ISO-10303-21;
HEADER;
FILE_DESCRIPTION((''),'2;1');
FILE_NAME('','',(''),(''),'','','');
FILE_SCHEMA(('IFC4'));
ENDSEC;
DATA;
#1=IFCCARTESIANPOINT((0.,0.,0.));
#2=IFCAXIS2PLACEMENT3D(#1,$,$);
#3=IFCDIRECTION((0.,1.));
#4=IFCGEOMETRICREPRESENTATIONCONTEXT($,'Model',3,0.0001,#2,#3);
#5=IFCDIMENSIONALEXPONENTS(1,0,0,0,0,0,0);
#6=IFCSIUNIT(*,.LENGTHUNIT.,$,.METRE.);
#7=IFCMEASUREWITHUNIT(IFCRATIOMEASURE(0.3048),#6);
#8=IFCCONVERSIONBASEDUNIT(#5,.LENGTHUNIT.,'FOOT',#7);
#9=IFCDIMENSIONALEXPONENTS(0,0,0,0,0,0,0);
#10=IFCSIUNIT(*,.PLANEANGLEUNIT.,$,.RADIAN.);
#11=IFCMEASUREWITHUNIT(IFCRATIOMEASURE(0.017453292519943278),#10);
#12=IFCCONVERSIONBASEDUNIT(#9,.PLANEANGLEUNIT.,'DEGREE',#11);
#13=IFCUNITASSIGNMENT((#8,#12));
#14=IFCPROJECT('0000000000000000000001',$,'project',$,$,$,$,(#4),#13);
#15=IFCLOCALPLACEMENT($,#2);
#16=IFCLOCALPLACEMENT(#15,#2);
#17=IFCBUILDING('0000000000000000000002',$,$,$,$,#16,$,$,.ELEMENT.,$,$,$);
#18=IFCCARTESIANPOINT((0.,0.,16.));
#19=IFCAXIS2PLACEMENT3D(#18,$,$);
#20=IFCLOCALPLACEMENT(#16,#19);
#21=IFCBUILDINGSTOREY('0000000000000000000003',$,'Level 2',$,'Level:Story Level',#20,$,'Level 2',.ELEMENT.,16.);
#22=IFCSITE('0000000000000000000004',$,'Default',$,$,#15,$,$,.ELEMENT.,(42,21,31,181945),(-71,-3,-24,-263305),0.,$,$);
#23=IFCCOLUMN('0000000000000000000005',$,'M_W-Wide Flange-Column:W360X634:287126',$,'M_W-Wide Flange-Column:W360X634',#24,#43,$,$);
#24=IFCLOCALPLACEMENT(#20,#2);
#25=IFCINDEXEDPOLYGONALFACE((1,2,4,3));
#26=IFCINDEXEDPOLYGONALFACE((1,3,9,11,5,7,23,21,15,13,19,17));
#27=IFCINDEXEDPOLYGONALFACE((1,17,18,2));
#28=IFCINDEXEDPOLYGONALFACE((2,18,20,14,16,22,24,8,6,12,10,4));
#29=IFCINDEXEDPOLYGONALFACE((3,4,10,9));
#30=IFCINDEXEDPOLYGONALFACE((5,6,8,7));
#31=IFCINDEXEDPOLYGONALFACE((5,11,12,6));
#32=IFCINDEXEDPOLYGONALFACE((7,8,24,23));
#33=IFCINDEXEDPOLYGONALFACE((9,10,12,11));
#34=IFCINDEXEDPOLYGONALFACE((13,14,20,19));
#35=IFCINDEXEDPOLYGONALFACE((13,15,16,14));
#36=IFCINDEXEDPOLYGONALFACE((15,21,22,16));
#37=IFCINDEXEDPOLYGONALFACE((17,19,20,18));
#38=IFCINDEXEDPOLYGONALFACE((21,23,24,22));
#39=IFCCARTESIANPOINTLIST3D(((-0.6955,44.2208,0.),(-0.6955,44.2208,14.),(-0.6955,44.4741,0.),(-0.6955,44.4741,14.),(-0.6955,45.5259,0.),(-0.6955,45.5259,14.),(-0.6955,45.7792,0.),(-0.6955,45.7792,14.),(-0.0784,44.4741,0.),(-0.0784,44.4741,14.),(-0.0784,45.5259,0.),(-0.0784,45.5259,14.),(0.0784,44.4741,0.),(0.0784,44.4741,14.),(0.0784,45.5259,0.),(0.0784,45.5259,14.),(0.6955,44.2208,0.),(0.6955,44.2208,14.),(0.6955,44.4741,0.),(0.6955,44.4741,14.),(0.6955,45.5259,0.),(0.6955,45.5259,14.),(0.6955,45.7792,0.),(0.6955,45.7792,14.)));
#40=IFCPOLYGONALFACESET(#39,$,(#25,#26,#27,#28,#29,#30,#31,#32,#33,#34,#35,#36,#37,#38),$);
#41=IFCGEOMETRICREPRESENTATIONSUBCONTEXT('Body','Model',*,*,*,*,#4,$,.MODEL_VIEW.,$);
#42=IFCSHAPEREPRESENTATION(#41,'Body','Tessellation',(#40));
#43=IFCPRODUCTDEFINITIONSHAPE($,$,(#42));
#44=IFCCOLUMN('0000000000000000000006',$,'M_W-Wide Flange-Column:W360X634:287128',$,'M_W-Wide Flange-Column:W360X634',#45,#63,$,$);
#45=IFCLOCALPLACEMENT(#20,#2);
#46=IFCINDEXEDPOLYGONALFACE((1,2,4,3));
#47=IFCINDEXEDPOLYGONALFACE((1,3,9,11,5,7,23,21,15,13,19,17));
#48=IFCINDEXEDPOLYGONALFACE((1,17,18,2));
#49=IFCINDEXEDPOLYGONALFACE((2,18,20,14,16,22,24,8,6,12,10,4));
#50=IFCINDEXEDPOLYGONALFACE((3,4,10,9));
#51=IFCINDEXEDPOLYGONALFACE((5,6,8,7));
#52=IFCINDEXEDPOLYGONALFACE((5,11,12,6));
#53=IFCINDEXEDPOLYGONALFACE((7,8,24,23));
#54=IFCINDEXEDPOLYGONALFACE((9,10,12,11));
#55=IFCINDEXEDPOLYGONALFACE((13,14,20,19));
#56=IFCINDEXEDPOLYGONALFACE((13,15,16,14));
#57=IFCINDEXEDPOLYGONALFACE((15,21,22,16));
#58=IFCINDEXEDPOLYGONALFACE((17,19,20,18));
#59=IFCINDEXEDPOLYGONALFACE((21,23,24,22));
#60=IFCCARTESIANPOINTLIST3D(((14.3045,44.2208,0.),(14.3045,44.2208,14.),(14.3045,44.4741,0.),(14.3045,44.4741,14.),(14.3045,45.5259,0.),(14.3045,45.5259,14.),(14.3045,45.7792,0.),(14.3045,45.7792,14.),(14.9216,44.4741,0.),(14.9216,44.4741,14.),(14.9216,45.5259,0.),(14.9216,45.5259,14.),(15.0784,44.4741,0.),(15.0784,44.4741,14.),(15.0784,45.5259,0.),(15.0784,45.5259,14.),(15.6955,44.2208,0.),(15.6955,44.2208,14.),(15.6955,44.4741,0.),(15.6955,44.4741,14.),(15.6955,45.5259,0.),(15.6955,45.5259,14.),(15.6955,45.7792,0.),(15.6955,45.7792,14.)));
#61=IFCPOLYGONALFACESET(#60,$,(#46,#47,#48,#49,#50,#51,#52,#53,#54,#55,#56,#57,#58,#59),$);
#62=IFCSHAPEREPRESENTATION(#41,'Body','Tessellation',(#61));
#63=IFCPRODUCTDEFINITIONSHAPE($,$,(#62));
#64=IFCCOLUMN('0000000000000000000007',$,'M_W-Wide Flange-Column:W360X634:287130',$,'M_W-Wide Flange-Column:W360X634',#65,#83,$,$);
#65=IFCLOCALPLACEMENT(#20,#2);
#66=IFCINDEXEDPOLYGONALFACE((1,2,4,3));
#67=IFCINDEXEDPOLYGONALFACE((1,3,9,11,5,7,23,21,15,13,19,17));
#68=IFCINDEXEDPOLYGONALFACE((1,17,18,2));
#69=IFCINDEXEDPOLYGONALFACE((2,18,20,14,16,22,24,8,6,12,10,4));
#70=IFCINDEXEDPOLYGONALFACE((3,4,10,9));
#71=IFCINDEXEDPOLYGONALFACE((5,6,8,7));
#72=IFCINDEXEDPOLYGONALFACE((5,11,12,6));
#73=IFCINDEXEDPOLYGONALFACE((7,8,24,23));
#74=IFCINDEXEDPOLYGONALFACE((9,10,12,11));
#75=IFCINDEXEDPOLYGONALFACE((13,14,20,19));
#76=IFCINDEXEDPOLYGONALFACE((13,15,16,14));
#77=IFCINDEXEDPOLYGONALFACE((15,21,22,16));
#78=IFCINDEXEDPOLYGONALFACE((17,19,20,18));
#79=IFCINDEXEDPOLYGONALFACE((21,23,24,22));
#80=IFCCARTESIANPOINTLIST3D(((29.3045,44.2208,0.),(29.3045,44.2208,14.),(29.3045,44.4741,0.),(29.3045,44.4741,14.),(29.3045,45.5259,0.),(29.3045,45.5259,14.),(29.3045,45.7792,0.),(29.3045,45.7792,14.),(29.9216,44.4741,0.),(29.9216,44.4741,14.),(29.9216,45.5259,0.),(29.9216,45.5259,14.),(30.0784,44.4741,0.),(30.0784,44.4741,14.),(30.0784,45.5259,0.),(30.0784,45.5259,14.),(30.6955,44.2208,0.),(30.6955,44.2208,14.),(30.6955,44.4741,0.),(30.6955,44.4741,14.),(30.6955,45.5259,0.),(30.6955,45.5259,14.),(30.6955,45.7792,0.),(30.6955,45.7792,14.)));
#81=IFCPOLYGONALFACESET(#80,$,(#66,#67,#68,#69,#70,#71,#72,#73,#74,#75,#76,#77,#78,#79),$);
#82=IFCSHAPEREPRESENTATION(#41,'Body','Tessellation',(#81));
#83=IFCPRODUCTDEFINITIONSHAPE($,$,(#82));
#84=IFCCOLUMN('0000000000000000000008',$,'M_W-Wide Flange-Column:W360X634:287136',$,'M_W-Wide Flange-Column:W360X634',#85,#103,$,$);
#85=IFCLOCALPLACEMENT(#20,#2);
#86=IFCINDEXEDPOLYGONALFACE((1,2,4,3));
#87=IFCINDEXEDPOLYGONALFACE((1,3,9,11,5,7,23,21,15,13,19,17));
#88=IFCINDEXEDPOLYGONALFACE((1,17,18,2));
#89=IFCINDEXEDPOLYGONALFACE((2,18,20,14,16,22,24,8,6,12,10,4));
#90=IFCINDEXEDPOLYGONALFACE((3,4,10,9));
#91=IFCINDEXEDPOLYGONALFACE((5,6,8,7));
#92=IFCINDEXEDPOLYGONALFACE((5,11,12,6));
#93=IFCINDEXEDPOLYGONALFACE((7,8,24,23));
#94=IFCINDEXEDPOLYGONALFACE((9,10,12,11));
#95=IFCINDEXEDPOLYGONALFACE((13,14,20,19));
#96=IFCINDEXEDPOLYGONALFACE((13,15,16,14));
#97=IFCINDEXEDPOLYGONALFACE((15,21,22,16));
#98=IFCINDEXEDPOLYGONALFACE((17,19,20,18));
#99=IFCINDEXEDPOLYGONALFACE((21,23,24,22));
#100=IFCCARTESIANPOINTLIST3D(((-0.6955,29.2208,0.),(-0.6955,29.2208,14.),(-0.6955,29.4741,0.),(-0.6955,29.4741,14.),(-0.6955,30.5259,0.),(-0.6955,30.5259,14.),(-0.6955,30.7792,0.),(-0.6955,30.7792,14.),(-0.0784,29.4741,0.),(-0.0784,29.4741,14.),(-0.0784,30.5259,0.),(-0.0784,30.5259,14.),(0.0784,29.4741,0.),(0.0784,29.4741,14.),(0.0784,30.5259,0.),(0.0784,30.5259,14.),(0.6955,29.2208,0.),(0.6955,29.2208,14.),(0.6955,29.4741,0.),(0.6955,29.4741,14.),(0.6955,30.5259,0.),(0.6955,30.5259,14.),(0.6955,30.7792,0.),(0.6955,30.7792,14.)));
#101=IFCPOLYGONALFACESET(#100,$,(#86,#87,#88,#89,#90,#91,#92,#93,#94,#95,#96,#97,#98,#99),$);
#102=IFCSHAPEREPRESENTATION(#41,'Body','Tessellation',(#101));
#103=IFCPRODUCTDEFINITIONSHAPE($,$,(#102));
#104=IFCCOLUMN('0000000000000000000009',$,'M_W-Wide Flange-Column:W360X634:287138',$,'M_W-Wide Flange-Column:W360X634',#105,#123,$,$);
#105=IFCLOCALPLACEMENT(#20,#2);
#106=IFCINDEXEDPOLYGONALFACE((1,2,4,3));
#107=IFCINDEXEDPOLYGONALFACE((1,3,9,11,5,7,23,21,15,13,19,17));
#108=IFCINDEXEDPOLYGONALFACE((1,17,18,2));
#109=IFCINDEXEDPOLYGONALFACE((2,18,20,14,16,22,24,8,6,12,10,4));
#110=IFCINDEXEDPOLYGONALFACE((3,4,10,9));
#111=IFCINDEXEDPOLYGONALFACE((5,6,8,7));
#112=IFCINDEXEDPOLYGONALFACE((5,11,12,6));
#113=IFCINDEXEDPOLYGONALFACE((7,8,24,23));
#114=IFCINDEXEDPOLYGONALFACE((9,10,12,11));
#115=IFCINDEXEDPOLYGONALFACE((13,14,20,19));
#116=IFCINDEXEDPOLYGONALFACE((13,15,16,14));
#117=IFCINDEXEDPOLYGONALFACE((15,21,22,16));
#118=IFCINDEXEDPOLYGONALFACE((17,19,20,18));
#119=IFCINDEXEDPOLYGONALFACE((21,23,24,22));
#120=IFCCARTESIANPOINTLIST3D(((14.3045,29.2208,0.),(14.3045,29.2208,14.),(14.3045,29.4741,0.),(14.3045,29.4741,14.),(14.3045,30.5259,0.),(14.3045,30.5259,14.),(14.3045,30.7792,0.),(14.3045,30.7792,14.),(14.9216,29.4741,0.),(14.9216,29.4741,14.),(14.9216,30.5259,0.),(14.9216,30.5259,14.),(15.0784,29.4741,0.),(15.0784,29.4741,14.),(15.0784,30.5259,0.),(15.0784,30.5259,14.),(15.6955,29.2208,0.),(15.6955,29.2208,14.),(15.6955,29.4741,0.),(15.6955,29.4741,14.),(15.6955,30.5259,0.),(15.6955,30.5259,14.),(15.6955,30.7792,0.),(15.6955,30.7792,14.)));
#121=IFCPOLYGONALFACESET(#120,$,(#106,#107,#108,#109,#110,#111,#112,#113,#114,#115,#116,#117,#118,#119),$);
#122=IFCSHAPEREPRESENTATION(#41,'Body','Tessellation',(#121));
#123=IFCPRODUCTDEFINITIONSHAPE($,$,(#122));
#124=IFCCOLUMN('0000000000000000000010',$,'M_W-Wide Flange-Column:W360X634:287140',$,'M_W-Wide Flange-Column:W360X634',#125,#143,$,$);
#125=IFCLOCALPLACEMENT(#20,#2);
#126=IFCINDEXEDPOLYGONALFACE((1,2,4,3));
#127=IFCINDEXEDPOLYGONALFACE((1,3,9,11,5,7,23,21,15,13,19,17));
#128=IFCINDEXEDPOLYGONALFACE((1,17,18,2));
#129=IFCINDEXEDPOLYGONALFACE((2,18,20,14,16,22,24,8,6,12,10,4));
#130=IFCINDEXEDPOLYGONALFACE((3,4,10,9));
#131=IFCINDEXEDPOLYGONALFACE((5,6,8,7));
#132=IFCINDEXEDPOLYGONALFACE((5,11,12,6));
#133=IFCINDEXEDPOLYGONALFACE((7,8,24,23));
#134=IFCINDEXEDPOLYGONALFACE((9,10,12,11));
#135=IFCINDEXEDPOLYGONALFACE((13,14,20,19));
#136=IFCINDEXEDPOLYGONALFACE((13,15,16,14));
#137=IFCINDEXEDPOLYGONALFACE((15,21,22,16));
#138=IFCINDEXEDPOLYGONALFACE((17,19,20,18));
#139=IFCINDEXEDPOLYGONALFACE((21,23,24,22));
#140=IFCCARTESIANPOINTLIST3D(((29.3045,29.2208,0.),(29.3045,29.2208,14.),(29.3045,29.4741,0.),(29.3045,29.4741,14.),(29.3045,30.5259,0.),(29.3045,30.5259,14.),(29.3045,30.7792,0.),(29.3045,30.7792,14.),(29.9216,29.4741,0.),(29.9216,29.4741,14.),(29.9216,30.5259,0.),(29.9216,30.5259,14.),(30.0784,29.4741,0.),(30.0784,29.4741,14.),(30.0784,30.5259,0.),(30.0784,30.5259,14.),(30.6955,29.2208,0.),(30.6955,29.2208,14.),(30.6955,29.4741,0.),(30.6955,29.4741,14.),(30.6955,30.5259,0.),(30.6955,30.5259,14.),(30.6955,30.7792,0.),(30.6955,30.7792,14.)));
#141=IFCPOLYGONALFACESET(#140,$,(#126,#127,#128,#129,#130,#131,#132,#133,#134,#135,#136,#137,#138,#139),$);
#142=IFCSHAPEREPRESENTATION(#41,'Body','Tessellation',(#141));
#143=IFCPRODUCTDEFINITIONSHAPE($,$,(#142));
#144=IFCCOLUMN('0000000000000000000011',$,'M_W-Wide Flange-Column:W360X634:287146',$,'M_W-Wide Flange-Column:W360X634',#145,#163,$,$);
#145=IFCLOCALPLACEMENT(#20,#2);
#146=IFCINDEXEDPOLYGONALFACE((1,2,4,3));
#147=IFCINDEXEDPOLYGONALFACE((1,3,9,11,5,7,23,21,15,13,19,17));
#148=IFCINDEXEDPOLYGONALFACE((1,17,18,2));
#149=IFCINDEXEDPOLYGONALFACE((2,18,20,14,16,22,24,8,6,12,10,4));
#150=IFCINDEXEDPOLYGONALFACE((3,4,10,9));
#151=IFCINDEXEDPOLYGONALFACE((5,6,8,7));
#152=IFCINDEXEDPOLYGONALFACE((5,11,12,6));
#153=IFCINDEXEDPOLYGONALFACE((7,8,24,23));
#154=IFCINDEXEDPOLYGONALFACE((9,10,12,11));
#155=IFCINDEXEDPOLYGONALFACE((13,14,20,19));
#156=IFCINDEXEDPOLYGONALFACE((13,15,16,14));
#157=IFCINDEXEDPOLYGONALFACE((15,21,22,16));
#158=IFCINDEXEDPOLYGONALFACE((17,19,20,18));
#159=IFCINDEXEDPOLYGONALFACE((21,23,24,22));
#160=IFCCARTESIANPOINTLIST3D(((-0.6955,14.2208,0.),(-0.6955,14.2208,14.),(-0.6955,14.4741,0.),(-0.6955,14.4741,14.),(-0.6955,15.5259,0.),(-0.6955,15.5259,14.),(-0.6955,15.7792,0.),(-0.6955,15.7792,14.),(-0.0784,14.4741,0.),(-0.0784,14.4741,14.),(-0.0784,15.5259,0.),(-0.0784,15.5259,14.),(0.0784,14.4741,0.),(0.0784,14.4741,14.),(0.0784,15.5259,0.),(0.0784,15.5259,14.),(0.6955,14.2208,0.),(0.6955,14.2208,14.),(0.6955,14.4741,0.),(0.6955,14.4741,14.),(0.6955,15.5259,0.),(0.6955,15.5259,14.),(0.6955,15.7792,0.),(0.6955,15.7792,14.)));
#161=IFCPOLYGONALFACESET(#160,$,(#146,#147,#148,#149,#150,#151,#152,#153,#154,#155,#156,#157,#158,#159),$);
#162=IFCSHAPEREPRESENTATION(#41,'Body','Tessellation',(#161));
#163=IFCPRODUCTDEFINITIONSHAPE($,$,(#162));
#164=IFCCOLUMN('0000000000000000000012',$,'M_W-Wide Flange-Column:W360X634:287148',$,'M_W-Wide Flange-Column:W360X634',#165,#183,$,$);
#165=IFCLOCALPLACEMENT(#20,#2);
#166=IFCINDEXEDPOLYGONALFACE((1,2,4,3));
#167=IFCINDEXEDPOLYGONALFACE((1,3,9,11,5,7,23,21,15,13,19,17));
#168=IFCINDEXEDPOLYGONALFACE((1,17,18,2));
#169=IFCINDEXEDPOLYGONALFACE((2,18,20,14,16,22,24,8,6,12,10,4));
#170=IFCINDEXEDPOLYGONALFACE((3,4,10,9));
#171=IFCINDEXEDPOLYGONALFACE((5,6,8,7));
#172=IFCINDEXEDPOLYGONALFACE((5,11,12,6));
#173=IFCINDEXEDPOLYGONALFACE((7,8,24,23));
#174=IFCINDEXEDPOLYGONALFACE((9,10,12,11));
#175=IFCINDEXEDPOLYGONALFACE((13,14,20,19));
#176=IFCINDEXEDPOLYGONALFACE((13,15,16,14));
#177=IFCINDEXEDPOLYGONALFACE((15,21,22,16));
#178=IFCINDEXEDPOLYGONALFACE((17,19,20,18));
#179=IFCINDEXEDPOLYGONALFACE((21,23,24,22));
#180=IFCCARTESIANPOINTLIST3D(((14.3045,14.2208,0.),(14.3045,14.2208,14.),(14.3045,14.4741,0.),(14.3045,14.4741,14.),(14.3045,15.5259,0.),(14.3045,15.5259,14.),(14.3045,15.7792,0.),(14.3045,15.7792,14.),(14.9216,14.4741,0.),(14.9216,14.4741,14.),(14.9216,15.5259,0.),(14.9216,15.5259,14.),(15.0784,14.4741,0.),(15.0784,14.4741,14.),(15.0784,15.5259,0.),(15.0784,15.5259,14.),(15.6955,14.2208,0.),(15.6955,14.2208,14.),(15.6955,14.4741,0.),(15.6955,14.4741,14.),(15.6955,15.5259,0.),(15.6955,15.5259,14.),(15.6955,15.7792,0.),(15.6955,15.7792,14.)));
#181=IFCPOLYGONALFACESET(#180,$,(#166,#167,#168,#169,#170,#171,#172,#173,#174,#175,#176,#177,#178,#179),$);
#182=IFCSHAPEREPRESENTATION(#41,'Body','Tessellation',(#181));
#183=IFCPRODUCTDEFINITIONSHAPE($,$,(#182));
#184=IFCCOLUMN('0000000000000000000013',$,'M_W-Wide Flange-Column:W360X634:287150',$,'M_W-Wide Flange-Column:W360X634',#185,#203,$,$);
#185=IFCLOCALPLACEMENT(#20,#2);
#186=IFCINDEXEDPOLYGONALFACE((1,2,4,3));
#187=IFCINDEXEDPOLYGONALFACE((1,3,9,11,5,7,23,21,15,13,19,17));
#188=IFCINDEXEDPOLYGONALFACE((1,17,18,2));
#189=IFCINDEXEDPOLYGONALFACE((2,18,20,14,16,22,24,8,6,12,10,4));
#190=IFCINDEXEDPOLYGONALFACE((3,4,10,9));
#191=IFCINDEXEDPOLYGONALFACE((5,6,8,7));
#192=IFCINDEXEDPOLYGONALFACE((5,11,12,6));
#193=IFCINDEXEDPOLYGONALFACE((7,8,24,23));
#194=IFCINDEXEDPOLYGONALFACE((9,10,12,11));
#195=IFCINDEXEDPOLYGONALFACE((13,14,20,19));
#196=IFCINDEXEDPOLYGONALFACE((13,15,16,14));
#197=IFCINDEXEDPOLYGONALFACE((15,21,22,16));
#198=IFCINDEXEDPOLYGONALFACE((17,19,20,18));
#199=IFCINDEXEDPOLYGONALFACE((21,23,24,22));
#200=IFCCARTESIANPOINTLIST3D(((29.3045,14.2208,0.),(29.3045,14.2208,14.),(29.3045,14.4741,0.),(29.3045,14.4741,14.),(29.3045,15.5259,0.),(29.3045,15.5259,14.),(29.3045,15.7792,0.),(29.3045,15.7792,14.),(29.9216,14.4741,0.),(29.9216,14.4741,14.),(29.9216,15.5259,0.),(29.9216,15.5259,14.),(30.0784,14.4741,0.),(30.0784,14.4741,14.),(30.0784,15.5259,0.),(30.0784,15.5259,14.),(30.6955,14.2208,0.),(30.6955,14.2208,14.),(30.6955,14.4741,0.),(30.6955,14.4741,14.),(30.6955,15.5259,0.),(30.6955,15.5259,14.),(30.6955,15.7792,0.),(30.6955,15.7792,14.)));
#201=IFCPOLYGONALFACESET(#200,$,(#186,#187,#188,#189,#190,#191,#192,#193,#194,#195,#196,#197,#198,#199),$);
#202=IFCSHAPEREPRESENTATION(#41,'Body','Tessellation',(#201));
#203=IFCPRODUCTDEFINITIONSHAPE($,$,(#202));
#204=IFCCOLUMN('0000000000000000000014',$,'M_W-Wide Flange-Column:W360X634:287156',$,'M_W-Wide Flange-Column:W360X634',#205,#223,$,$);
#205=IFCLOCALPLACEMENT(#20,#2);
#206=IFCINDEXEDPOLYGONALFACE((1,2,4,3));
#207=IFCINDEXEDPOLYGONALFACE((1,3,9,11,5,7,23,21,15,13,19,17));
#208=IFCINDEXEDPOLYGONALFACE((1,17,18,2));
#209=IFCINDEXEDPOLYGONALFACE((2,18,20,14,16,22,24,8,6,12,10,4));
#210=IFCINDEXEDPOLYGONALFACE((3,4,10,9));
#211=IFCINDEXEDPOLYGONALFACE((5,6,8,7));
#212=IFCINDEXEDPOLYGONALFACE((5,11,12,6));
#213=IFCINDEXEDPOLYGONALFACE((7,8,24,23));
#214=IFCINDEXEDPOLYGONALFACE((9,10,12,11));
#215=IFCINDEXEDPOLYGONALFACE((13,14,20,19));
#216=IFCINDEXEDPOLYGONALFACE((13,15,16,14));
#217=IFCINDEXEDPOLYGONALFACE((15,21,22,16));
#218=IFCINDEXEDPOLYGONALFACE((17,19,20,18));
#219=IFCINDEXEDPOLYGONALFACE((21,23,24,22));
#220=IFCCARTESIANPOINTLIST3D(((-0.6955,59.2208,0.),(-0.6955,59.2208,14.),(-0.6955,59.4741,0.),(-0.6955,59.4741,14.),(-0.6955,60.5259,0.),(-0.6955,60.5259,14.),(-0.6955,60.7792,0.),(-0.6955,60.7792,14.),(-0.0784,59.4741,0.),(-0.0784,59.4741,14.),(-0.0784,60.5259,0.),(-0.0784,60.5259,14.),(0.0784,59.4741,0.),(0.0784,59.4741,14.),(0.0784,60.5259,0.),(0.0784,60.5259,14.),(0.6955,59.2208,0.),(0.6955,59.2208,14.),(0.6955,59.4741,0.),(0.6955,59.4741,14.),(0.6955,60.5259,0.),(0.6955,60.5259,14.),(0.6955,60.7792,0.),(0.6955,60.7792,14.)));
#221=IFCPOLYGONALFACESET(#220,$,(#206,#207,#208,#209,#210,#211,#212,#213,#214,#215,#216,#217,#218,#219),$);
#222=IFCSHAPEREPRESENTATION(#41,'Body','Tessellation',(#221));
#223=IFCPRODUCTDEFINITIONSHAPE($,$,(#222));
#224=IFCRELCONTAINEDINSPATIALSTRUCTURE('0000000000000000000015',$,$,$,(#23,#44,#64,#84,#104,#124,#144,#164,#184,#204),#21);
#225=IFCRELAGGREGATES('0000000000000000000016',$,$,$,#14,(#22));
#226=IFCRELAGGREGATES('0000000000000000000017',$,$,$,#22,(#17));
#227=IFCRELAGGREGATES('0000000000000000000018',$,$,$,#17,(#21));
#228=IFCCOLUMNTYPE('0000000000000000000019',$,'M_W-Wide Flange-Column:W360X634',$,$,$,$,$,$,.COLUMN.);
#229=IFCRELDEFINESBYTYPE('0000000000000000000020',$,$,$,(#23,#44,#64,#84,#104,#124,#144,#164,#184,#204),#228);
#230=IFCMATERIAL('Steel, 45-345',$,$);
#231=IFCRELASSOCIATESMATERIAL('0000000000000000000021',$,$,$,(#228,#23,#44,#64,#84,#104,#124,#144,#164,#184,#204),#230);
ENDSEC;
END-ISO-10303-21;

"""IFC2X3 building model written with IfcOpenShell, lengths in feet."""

from ifc_helpers import new_model, entity, si_unit, converted_unit, direction, frame, origin, place, context, subcontext, project, spatial, polyline, outline, extrude, source, transform, mapped, material, type_object, type_shapes, element, save


model = new_model("IFC2X3")

# Units and contexts
model_context = context("Model", 3, precision=0.0001, world=origin(), true_north=direction((0.0, 1.0)))
body_context = subcontext(model_context, "Body", "Model", "MODEL_VIEW")
ifc_project = project(units=[converted_unit("LENGTHUNIT", "FOOT", entity("IfcRatioMeasure", 0.3048), si_unit("LENGTHUNIT", "METRE"), dimensions=[1, 0, 0, 0, 0, 0, 0]), converted_unit("PLANEANGLEUNIT", "DEGREE", entity("IfcRatioMeasure", 0.017453292519943278), si_unit("PLANEANGLEUNIT", "RADIAN"), dimensions=[0, 0, 0, 0, 0, 0, 0])], contexts=[model_context])

# Site, building, storey
site_placement = place(None, origin())
site = spatial("IfcSite", under=ifc_project, at=site_placement, Name="Default", CompositionType="ELEMENT", RefLatitude=(42, 21, 31, 181945), RefLongitude=(-71, -3, -24, -263305), RefElevation=0.0)
building_placement = place(site_placement, origin())
building = spatial("IfcBuilding", under=site, at=building_placement, CompositionType="ELEMENT")
storey_placement = place(building_placement, frame((0.0, 0.0, 16.0)))
storey = spatial("IfcBuildingStorey", under=building, at=storey_placement, Name="Level 2", ObjectType="Level:Story Level", LongName="Level 2", CompositionType="ELEMENT", Elevation=16.0)

# Columns
ifc_material = material(Name="Steel, 45-345")
column_type = type_object("IfcColumnType", Name="M_W-Wide Flange-Column:W360X634", PredefinedType="COLUMN", material=ifc_material)
shared_shape = source(origin(), body_context, "Body", "SweptSolid", [
    extrude(outline(polyline([(0.5259, -0.6955), (0.7792, -0.6955), (0.7792, 0.6955), (0.5259, 0.6955), (0.5259, 0.0784), (-0.5259, 0.0784), (-0.5259, 0.6955), (-0.7792, 0.6955), (-0.7792, -0.6955), (-0.5259, -0.6955), (-0.5259, -0.0784), (0.5259, -0.0784), (0.5259, -0.6955)])), frame((0.0, 0.0, 16.0), z_axis=(0.0, 0.0, 1.0), x_axis=(0.0, -1.0, 0.0)), (0.0, 0.0, 1.0), 14.0),
])
type_shapes(column_type, [shared_shape])
for number, where, name in (
    (1, (0.0, 45.0, -16.0), "M_W-Wide Flange-Column:W360X634:287126"),
    (2, (15.0, 45.0, -16.0), "M_W-Wide Flange-Column:W360X634:287128"),
    (3, (30.0, 45.0, -16.0), "M_W-Wide Flange-Column:W360X634:287130"),
    (4, (0.0, 30.0, -16.0), "M_W-Wide Flange-Column:W360X634:287136"),
    (5, (15.0, 30.0, -16.0), "M_W-Wide Flange-Column:W360X634:287138"),
    (6, (30.0, 30.0, -16.0), "M_W-Wide Flange-Column:W360X634:287140"),
    (7, (0.0, 15.0, -16.0), "M_W-Wide Flange-Column:W360X634:287146"),
    (8, (15.0, 15.0, -16.0), "M_W-Wide Flange-Column:W360X634:287148"),
    (9, (30.0, 15.0, -16.0), "M_W-Wide Flange-Column:W360X634:287150"),
    (10, (0.0, 60.0, -16.0), "M_W-Wide Flange-Column:W360X634:287156"),
):
    element("IfcColumn", number, at=place(storey_placement, frame(where)), inside=storey, type_object=column_type, material=ifc_material, Name=name, ObjectType="M_W-Wide Flange-Column:W360X634", context=body_context, shape_type="MappedRepresentation", body=[
        mapped(shared_shape, transform((0.0, 0.0, 0.0), scale=1.0)),
    ])

save(model, "model.ifc")
